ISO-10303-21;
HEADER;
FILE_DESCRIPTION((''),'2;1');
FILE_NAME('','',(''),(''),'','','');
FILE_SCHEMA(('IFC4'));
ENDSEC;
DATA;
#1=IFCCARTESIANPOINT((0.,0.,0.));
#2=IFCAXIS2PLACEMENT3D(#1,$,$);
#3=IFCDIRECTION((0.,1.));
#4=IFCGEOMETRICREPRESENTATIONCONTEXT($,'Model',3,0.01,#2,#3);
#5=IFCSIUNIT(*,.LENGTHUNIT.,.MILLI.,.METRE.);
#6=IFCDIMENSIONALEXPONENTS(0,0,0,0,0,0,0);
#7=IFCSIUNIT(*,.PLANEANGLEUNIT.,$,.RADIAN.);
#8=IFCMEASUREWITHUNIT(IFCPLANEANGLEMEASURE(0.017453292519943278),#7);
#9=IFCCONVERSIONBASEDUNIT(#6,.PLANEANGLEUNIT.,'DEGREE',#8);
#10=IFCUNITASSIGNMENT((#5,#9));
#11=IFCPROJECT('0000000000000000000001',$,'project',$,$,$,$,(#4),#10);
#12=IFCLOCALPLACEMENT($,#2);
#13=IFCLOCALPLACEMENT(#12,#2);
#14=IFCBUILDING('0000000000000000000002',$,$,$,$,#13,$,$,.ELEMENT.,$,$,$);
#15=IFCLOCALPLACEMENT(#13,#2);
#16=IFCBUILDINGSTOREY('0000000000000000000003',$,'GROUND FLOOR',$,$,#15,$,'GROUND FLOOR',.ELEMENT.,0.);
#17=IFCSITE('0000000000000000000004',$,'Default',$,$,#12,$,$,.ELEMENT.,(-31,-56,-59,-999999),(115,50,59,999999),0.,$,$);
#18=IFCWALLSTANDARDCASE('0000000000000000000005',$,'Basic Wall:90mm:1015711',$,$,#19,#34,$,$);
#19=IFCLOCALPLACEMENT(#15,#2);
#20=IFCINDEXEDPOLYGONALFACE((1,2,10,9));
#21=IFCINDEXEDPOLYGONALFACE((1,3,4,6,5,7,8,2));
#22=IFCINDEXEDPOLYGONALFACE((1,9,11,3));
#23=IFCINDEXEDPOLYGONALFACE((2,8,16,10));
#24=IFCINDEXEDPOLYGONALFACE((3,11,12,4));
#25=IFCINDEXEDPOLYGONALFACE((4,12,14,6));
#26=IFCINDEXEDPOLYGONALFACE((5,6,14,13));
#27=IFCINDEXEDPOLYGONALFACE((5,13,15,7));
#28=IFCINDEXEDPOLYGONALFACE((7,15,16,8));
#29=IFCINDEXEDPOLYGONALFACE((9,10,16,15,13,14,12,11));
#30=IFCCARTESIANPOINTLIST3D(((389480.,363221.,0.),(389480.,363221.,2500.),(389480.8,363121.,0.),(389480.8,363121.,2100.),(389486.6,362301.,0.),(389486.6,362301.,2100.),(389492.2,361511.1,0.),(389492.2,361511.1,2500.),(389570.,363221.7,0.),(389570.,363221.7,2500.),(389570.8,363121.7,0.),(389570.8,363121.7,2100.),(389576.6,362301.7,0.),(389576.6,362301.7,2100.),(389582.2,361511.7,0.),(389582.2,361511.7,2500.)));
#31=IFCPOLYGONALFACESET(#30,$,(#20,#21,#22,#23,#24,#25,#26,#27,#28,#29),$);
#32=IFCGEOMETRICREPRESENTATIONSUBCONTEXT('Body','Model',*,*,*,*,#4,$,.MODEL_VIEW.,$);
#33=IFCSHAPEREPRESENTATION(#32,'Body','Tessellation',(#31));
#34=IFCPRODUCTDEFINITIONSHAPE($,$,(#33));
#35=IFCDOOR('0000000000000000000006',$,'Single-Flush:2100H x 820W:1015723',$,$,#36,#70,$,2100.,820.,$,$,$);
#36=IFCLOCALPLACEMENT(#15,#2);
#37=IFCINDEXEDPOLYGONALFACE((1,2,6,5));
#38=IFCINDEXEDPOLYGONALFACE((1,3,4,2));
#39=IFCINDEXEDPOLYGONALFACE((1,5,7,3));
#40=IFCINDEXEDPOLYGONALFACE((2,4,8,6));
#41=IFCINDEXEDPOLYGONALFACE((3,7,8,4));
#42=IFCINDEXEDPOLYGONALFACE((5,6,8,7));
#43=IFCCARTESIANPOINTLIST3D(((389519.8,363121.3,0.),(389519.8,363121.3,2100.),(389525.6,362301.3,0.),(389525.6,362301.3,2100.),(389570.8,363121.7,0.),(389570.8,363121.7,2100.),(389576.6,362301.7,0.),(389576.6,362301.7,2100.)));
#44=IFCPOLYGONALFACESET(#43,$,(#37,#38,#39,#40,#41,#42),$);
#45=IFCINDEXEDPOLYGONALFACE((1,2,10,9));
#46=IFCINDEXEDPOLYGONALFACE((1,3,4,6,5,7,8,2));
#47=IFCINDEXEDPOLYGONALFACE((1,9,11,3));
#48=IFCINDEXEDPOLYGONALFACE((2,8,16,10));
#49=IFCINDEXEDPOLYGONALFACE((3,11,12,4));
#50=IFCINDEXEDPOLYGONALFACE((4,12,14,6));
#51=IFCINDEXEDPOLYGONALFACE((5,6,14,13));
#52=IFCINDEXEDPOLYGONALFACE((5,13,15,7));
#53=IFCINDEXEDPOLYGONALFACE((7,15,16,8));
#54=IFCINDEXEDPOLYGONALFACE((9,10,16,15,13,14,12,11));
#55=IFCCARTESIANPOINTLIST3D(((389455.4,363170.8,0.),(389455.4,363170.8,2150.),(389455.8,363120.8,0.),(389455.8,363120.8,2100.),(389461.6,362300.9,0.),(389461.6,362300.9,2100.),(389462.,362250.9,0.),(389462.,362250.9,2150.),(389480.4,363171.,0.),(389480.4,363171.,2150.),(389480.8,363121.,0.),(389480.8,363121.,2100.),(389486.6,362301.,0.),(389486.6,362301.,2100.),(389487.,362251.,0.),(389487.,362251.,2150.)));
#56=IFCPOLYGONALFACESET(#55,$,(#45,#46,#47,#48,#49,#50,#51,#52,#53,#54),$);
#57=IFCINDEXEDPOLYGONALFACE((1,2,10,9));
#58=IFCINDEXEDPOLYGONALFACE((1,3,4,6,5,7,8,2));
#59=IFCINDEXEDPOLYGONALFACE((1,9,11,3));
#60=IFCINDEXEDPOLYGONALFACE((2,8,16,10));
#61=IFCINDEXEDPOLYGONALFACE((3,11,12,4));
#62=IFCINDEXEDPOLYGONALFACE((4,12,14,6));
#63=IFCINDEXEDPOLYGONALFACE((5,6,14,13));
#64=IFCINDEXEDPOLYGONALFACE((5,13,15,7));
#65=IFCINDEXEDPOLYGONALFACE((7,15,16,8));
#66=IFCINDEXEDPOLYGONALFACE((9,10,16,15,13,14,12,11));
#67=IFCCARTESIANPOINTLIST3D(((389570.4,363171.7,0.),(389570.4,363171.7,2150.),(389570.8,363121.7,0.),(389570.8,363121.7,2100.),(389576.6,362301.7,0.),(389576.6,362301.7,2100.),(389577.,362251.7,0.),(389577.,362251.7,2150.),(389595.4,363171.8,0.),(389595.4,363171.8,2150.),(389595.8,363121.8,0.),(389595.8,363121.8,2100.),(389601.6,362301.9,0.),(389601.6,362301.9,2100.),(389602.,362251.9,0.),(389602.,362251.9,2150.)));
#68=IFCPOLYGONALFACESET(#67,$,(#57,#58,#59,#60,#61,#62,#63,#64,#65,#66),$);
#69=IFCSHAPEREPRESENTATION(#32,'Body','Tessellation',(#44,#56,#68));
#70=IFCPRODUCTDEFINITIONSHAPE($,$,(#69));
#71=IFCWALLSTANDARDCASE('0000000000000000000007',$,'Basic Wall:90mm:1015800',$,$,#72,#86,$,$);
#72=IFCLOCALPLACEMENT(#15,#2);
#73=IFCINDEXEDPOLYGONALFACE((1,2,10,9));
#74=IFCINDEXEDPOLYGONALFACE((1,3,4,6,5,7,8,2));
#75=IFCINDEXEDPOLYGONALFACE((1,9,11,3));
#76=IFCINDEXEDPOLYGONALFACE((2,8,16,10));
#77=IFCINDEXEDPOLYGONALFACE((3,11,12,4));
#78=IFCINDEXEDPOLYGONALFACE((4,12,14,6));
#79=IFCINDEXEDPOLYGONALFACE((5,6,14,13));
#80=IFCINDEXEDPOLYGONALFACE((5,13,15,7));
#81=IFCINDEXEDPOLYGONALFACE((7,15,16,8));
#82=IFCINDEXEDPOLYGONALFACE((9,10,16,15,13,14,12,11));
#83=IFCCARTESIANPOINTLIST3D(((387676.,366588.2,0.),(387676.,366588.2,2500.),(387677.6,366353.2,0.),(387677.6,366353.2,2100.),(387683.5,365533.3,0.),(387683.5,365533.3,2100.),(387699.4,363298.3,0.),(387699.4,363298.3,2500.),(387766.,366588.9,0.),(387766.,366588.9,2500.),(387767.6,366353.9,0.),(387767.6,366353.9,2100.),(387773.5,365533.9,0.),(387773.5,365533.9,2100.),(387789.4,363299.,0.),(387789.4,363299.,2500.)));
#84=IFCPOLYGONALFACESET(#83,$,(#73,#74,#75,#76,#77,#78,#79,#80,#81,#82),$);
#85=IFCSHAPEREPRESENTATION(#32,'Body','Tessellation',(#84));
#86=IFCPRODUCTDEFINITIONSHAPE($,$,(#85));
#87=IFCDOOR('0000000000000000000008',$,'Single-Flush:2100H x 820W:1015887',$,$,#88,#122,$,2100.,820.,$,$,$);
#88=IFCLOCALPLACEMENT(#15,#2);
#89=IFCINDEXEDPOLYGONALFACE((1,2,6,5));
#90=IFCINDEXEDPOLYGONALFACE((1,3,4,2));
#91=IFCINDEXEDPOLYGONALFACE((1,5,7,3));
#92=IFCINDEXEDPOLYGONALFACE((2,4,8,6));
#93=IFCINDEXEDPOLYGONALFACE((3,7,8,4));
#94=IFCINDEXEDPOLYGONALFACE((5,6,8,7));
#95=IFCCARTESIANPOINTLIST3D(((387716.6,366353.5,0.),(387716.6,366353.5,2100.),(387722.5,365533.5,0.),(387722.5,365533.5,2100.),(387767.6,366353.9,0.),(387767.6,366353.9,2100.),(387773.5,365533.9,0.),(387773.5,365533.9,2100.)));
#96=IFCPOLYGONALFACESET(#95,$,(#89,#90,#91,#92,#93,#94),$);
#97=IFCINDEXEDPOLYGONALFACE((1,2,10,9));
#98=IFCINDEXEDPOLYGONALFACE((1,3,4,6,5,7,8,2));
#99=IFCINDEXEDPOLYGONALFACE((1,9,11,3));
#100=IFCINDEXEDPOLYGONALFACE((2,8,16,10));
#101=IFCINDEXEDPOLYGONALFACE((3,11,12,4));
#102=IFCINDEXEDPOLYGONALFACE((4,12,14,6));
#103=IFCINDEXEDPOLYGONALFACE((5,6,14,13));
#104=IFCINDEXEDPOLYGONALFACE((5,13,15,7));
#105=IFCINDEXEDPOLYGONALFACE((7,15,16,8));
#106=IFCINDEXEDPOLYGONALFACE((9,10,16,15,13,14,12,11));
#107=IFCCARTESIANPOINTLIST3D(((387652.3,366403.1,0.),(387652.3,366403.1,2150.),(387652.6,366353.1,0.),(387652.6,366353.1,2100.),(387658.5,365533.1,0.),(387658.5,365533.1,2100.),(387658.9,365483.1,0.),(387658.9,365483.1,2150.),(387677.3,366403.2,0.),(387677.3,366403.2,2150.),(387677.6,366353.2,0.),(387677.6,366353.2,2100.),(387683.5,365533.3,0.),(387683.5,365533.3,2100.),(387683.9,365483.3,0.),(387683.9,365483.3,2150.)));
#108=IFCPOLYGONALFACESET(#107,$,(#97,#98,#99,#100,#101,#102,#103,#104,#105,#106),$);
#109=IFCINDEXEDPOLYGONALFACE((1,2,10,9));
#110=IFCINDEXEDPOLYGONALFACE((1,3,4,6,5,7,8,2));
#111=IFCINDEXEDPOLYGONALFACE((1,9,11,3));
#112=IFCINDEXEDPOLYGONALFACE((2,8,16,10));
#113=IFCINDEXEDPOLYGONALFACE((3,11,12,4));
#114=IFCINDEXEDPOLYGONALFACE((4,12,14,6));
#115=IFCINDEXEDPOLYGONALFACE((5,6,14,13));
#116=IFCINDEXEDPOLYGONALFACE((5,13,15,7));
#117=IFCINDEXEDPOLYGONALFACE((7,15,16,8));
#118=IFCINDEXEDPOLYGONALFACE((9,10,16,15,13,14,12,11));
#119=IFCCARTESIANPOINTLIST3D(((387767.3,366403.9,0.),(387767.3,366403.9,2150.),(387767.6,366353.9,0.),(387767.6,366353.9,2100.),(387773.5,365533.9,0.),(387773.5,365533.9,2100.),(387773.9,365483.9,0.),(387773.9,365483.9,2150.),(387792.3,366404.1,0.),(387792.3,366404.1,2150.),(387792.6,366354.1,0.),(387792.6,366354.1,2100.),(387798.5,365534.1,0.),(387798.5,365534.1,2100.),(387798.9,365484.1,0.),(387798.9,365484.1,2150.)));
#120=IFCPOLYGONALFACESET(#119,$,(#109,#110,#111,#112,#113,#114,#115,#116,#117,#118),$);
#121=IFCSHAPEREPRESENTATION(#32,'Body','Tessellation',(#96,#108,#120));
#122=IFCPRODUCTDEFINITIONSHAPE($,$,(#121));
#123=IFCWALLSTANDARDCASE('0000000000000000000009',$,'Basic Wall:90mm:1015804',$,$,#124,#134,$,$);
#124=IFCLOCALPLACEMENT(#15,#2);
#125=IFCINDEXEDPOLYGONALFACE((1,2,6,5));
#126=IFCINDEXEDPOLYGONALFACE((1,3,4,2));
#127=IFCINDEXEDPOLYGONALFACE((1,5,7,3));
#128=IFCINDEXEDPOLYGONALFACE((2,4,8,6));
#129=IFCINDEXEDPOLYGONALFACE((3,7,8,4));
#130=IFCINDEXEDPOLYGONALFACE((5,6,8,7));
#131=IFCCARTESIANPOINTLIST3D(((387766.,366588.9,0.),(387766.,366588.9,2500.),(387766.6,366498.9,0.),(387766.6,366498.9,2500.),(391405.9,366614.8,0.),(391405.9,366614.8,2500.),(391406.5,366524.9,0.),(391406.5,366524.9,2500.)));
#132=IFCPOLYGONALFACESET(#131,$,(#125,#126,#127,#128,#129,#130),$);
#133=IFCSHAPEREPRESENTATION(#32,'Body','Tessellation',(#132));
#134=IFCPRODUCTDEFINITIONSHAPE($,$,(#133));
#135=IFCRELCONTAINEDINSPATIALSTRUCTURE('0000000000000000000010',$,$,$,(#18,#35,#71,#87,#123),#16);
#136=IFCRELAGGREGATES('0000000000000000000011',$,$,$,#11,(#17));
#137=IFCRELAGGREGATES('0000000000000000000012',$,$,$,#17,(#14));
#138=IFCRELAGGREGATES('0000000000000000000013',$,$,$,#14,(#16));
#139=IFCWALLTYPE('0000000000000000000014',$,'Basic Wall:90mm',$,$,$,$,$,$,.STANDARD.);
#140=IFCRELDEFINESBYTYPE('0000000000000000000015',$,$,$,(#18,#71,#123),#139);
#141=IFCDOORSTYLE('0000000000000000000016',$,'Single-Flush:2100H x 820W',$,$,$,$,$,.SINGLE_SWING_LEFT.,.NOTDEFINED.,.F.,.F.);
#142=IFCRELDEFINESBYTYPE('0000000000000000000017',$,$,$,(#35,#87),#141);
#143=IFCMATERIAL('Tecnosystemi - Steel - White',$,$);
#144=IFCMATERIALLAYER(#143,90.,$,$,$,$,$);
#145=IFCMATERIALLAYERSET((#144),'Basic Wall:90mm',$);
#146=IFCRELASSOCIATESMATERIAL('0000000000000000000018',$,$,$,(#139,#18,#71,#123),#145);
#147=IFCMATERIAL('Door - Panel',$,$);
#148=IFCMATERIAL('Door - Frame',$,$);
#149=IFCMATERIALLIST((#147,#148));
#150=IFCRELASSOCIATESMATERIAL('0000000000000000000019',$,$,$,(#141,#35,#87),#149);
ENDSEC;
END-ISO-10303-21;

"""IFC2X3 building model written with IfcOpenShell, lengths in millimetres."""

from ifc_helpers import new_model, entity, si_unit, converted_unit, direction, frame, frame_2d, origin, origin_2d_with_axis, place, context, subcontext, project, spatial, polyline, rectangle, outline, extrude, source, transform, mapped, material, material_list, layer, layer_set, layer_usage, type_object, type_shapes, element, fill, save


model = new_model("IFC2X3")

# Units and contexts
model_context = context("Model", 3, precision=0.01, world=origin(), true_north=direction((0.0, 1.0)))
body_context = subcontext(model_context, "Body", "Model", "MODEL_VIEW")
ifc_project = project(units=[si_unit("LENGTHUNIT", "METRE", prefix="MILLI"), converted_unit("PLANEANGLEUNIT", "DEGREE", entity("IfcPlaneAngleMeasure", 0.017453292519943278), si_unit("PLANEANGLEUNIT", "RADIAN"), dimensions=[0, 0, 0, 0, 0, 0, 0])], contexts=[model_context])

# Site, building, storey
site_placement = place(None, origin())
site = spatial("IfcSite", under=ifc_project, at=site_placement, Name="Default", CompositionType="ELEMENT", RefLatitude=(-31, -56, -59, -999999), RefLongitude=(115, 50, 59, 999999), RefElevation=0.0)
building_placement = place(site_placement, origin())
building = spatial("IfcBuilding", under=site, at=building_placement, CompositionType="ELEMENT")
storey_placement = place(building_placement, origin())
storey = spatial("IfcBuildingStorey", under=building, at=storey_placement, Name="GROUND FLOOR", LongName="GROUND FLOOR", CompositionType="ELEMENT", Elevation=0.0)

# Shared definitions
ifc_material_1 = material(Name="Tecnosystemi - Steel - White")
ifc_layer_1 = layer(ifc_material_1, 90.0)
ifc_layer_set_1 = layer_set([ifc_layer_1], Name="Basic Wall:90mm")
wall_type_1 = type_object("IfcWallType", Name="Basic Wall:90mm", PredefinedType="STANDARD", material=ifc_layer_set_1)

# Shared definitions
ifc_material_2 = material(Name="Door - Panel")
ifc_material_3 = material(Name="Door - Frame")
ifc_material_list_1 = material_list([ifc_material_2, ifc_material_3])
door_style_1 = type_object("IfcDoorStyle", Name="Single-Flush:2100H x 820W", ConstructionType="NOTDEFINED", OperationType="SINGLE_SWING_LEFT", ParameterTakesPrecedence=False, Sizeable=False, material=ifc_material_list_1)
shared_shape_1 = source(origin(), body_context, "Body", "SweptSolid", [
    extrude(rectangle(XDim=820.0, YDim=51.0, at=origin_2d_with_axis()), frame((410.0, 64.5, 0.0)), (0.0, 0.0, 1.0), 2100.0),
    extrude(outline(polyline([(-1087.5, -460.0), (1062.5, -460.0), (1062.5, -410.0), (-1037.5, -410.0), (-1037.5, 410.0), (1062.5, 410.0), (1062.5, 460.0), (-1087.5, 460.0), (-1087.5, -460.0)])), frame((410.0, 0.0, 1062.5), z_axis=(0.0, -1.0, 0.0), x_axis=(0.0, 0.0, -1.0)), (0.0, 0.0, 1.0), 25.0),
    extrude(outline(polyline([(-460.0, -1087.5), (460.0, -1087.5), (460.0, 1062.5), (410.0, 1062.5), (410.0, -1037.5), (-410.0, -1037.5), (-410.0, 1062.5), (-460.0, 1062.5), (-460.0, -1087.5)])), frame((410.0, 115.0, 1062.5), z_axis=(0.0, -1.0, 0.0), x_axis=(-1.0, 0.0, 0.0)), (0.0, 0.0, 1.0), 25.0),
])
type_shapes(door_style_1, [shared_shape_1])

# Walls, openings, doors
ifc_layer_usage_1 = layer_usage(ifc_layer_set_1, "AXIS2", "NEGATIVE", 45.0)
wall_1_placement = place(storey_placement, frame((389525.0, 363221.3, 0.0), z_axis=(0.0, 0.0, 1.0), x_axis=(0.007134, -0.999975, 0.0)))
wall_1 = element("IfcWallStandardCase", 1, at=wall_1_placement, inside=storey, type_object=wall_type_1, material=ifc_layer_usage_1, Name="Basic Wall:90mm:1015711", context=body_context, shape_type="SweptSolid", body=[
    extrude(rectangle(XDim=1710.0, YDim=90.0, at=frame_2d((855.0, 0.0), x_axis=(1.0, 0.0))), origin(), (0.0, 0.0, 1.0), 2500.0),
])
opening_1_placement = place(wall_1_placement, frame((100.0, -45.0, 0.0)))
opening_1 = element("IfcOpeningElement", 2, at=opening_1_placement, cuts=wall_1, ObjectType="Opening", context=body_context, shape_type="SweptSolid", body=[
    extrude(rectangle(XDim=820.0, YDim=2100.0, at=frame_2d((1050.0, 410.0), x_axis=(0.0, -1.0))), frame((0.0, 0.0, 0.0), z_axis=(0.0, 1.0, 0.0), x_axis=(0.0, 0.0, 1.0)), (0.0, 0.0, 1.0), 90.0),
])
door_1_placement = place(opening_1_placement, origin())
door_1 = element("IfcDoor", 3, at=door_1_placement, inside=storey, type_object=door_style_1, material=ifc_material_list_1, Name="Single-Flush:2100H x 820W:1015723", OverallHeight=2100.0, OverallWidth=820.0, context=body_context, shape_type="MappedRepresentation", body=[
    mapped(shared_shape_1, transform((0.0, 0.0, 0.0), scale=1.0)),
])
fill(opening_1, door_1)
ifc_layer_usage_2 = layer_usage(ifc_layer_set_1, "AXIS2", "NEGATIVE", 45.0)
wall_2_placement = place(storey_placement, frame((387744.4, 363298.6, 0.0), z_axis=(0.0, 0.0, 1.0), x_axis=(-0.007134, 0.999975, 0.0)))
wall_2 = element("IfcWallStandardCase", 4, at=wall_2_placement, inside=storey, type_object=wall_type_1, material=ifc_layer_usage_2, Name="Basic Wall:90mm:1015800", context=body_context, shape_type="SweptSolid", body=[
    extrude(rectangle(XDim=3290.0, YDim=90.0, at=frame_2d((1645.0, 0.0), x_axis=(1.0, 0.0))), origin(), (0.0, 0.0, 1.0), 2500.0),
])
opening_2_placement = place(wall_2_placement, frame((3055.0, 45.0, 0.0)))
opening_2 = element("IfcOpeningElement", 5, at=opening_2_placement, cuts=wall_2, ObjectType="Opening", context=body_context, shape_type="SweptSolid", body=[
    extrude(rectangle(XDim=820.0, YDim=2100.0, at=frame_2d((1050.0, 410.0), x_axis=(0.0, -1.0))), frame((0.0, 0.0, 0.0), z_axis=(0.0, -1.0, 0.0), x_axis=(0.0, 0.0, 1.0)), (0.0, 0.0, 1.0), 90.0),
])
door_2_placement = place(opening_2_placement, frame((0.0, 0.0, 0.0), z_axis=(0.0, 0.0, 1.0), x_axis=(-1.0, 0.0, 0.0)))
door_2 = element("IfcDoor", 6, at=door_2_placement, inside=storey, type_object=door_style_1, material=ifc_material_list_1, Name="Single-Flush:2100H x 820W:1015887", OverallHeight=2100.0, OverallWidth=820.0, context=body_context, shape_type="MappedRepresentation", body=[
    mapped(shared_shape_1, transform((0.0, 0.0, 0.0), scale=1.0)),
])
fill(opening_2, door_2)

# Wall
ifc_layer_usage_3 = layer_usage(ifc_layer_set_1, "AXIS2", "NEGATIVE", 45.0)
wall_3_placement = place(storey_placement, frame((387766.3, 366543.9, 0.0), z_axis=(0.0, 0.0, 1.0), x_axis=(0.999975, 0.007134, 0.0)))
element("IfcWallStandardCase", 7, at=wall_3_placement, inside=storey, type_object=wall_type_1, material=ifc_layer_usage_3, Name="Basic Wall:90mm:1015804", context=body_context, shape_type="SweptSolid", body=[
    extrude(rectangle(XDim=3640.0, YDim=90.0, at=frame_2d((1820.0, 0.0), x_axis=(-1.0, 0.0))), origin(), (0.0, 0.0, 1.0), 2500.0),
])

save(model, "model.ifc")
